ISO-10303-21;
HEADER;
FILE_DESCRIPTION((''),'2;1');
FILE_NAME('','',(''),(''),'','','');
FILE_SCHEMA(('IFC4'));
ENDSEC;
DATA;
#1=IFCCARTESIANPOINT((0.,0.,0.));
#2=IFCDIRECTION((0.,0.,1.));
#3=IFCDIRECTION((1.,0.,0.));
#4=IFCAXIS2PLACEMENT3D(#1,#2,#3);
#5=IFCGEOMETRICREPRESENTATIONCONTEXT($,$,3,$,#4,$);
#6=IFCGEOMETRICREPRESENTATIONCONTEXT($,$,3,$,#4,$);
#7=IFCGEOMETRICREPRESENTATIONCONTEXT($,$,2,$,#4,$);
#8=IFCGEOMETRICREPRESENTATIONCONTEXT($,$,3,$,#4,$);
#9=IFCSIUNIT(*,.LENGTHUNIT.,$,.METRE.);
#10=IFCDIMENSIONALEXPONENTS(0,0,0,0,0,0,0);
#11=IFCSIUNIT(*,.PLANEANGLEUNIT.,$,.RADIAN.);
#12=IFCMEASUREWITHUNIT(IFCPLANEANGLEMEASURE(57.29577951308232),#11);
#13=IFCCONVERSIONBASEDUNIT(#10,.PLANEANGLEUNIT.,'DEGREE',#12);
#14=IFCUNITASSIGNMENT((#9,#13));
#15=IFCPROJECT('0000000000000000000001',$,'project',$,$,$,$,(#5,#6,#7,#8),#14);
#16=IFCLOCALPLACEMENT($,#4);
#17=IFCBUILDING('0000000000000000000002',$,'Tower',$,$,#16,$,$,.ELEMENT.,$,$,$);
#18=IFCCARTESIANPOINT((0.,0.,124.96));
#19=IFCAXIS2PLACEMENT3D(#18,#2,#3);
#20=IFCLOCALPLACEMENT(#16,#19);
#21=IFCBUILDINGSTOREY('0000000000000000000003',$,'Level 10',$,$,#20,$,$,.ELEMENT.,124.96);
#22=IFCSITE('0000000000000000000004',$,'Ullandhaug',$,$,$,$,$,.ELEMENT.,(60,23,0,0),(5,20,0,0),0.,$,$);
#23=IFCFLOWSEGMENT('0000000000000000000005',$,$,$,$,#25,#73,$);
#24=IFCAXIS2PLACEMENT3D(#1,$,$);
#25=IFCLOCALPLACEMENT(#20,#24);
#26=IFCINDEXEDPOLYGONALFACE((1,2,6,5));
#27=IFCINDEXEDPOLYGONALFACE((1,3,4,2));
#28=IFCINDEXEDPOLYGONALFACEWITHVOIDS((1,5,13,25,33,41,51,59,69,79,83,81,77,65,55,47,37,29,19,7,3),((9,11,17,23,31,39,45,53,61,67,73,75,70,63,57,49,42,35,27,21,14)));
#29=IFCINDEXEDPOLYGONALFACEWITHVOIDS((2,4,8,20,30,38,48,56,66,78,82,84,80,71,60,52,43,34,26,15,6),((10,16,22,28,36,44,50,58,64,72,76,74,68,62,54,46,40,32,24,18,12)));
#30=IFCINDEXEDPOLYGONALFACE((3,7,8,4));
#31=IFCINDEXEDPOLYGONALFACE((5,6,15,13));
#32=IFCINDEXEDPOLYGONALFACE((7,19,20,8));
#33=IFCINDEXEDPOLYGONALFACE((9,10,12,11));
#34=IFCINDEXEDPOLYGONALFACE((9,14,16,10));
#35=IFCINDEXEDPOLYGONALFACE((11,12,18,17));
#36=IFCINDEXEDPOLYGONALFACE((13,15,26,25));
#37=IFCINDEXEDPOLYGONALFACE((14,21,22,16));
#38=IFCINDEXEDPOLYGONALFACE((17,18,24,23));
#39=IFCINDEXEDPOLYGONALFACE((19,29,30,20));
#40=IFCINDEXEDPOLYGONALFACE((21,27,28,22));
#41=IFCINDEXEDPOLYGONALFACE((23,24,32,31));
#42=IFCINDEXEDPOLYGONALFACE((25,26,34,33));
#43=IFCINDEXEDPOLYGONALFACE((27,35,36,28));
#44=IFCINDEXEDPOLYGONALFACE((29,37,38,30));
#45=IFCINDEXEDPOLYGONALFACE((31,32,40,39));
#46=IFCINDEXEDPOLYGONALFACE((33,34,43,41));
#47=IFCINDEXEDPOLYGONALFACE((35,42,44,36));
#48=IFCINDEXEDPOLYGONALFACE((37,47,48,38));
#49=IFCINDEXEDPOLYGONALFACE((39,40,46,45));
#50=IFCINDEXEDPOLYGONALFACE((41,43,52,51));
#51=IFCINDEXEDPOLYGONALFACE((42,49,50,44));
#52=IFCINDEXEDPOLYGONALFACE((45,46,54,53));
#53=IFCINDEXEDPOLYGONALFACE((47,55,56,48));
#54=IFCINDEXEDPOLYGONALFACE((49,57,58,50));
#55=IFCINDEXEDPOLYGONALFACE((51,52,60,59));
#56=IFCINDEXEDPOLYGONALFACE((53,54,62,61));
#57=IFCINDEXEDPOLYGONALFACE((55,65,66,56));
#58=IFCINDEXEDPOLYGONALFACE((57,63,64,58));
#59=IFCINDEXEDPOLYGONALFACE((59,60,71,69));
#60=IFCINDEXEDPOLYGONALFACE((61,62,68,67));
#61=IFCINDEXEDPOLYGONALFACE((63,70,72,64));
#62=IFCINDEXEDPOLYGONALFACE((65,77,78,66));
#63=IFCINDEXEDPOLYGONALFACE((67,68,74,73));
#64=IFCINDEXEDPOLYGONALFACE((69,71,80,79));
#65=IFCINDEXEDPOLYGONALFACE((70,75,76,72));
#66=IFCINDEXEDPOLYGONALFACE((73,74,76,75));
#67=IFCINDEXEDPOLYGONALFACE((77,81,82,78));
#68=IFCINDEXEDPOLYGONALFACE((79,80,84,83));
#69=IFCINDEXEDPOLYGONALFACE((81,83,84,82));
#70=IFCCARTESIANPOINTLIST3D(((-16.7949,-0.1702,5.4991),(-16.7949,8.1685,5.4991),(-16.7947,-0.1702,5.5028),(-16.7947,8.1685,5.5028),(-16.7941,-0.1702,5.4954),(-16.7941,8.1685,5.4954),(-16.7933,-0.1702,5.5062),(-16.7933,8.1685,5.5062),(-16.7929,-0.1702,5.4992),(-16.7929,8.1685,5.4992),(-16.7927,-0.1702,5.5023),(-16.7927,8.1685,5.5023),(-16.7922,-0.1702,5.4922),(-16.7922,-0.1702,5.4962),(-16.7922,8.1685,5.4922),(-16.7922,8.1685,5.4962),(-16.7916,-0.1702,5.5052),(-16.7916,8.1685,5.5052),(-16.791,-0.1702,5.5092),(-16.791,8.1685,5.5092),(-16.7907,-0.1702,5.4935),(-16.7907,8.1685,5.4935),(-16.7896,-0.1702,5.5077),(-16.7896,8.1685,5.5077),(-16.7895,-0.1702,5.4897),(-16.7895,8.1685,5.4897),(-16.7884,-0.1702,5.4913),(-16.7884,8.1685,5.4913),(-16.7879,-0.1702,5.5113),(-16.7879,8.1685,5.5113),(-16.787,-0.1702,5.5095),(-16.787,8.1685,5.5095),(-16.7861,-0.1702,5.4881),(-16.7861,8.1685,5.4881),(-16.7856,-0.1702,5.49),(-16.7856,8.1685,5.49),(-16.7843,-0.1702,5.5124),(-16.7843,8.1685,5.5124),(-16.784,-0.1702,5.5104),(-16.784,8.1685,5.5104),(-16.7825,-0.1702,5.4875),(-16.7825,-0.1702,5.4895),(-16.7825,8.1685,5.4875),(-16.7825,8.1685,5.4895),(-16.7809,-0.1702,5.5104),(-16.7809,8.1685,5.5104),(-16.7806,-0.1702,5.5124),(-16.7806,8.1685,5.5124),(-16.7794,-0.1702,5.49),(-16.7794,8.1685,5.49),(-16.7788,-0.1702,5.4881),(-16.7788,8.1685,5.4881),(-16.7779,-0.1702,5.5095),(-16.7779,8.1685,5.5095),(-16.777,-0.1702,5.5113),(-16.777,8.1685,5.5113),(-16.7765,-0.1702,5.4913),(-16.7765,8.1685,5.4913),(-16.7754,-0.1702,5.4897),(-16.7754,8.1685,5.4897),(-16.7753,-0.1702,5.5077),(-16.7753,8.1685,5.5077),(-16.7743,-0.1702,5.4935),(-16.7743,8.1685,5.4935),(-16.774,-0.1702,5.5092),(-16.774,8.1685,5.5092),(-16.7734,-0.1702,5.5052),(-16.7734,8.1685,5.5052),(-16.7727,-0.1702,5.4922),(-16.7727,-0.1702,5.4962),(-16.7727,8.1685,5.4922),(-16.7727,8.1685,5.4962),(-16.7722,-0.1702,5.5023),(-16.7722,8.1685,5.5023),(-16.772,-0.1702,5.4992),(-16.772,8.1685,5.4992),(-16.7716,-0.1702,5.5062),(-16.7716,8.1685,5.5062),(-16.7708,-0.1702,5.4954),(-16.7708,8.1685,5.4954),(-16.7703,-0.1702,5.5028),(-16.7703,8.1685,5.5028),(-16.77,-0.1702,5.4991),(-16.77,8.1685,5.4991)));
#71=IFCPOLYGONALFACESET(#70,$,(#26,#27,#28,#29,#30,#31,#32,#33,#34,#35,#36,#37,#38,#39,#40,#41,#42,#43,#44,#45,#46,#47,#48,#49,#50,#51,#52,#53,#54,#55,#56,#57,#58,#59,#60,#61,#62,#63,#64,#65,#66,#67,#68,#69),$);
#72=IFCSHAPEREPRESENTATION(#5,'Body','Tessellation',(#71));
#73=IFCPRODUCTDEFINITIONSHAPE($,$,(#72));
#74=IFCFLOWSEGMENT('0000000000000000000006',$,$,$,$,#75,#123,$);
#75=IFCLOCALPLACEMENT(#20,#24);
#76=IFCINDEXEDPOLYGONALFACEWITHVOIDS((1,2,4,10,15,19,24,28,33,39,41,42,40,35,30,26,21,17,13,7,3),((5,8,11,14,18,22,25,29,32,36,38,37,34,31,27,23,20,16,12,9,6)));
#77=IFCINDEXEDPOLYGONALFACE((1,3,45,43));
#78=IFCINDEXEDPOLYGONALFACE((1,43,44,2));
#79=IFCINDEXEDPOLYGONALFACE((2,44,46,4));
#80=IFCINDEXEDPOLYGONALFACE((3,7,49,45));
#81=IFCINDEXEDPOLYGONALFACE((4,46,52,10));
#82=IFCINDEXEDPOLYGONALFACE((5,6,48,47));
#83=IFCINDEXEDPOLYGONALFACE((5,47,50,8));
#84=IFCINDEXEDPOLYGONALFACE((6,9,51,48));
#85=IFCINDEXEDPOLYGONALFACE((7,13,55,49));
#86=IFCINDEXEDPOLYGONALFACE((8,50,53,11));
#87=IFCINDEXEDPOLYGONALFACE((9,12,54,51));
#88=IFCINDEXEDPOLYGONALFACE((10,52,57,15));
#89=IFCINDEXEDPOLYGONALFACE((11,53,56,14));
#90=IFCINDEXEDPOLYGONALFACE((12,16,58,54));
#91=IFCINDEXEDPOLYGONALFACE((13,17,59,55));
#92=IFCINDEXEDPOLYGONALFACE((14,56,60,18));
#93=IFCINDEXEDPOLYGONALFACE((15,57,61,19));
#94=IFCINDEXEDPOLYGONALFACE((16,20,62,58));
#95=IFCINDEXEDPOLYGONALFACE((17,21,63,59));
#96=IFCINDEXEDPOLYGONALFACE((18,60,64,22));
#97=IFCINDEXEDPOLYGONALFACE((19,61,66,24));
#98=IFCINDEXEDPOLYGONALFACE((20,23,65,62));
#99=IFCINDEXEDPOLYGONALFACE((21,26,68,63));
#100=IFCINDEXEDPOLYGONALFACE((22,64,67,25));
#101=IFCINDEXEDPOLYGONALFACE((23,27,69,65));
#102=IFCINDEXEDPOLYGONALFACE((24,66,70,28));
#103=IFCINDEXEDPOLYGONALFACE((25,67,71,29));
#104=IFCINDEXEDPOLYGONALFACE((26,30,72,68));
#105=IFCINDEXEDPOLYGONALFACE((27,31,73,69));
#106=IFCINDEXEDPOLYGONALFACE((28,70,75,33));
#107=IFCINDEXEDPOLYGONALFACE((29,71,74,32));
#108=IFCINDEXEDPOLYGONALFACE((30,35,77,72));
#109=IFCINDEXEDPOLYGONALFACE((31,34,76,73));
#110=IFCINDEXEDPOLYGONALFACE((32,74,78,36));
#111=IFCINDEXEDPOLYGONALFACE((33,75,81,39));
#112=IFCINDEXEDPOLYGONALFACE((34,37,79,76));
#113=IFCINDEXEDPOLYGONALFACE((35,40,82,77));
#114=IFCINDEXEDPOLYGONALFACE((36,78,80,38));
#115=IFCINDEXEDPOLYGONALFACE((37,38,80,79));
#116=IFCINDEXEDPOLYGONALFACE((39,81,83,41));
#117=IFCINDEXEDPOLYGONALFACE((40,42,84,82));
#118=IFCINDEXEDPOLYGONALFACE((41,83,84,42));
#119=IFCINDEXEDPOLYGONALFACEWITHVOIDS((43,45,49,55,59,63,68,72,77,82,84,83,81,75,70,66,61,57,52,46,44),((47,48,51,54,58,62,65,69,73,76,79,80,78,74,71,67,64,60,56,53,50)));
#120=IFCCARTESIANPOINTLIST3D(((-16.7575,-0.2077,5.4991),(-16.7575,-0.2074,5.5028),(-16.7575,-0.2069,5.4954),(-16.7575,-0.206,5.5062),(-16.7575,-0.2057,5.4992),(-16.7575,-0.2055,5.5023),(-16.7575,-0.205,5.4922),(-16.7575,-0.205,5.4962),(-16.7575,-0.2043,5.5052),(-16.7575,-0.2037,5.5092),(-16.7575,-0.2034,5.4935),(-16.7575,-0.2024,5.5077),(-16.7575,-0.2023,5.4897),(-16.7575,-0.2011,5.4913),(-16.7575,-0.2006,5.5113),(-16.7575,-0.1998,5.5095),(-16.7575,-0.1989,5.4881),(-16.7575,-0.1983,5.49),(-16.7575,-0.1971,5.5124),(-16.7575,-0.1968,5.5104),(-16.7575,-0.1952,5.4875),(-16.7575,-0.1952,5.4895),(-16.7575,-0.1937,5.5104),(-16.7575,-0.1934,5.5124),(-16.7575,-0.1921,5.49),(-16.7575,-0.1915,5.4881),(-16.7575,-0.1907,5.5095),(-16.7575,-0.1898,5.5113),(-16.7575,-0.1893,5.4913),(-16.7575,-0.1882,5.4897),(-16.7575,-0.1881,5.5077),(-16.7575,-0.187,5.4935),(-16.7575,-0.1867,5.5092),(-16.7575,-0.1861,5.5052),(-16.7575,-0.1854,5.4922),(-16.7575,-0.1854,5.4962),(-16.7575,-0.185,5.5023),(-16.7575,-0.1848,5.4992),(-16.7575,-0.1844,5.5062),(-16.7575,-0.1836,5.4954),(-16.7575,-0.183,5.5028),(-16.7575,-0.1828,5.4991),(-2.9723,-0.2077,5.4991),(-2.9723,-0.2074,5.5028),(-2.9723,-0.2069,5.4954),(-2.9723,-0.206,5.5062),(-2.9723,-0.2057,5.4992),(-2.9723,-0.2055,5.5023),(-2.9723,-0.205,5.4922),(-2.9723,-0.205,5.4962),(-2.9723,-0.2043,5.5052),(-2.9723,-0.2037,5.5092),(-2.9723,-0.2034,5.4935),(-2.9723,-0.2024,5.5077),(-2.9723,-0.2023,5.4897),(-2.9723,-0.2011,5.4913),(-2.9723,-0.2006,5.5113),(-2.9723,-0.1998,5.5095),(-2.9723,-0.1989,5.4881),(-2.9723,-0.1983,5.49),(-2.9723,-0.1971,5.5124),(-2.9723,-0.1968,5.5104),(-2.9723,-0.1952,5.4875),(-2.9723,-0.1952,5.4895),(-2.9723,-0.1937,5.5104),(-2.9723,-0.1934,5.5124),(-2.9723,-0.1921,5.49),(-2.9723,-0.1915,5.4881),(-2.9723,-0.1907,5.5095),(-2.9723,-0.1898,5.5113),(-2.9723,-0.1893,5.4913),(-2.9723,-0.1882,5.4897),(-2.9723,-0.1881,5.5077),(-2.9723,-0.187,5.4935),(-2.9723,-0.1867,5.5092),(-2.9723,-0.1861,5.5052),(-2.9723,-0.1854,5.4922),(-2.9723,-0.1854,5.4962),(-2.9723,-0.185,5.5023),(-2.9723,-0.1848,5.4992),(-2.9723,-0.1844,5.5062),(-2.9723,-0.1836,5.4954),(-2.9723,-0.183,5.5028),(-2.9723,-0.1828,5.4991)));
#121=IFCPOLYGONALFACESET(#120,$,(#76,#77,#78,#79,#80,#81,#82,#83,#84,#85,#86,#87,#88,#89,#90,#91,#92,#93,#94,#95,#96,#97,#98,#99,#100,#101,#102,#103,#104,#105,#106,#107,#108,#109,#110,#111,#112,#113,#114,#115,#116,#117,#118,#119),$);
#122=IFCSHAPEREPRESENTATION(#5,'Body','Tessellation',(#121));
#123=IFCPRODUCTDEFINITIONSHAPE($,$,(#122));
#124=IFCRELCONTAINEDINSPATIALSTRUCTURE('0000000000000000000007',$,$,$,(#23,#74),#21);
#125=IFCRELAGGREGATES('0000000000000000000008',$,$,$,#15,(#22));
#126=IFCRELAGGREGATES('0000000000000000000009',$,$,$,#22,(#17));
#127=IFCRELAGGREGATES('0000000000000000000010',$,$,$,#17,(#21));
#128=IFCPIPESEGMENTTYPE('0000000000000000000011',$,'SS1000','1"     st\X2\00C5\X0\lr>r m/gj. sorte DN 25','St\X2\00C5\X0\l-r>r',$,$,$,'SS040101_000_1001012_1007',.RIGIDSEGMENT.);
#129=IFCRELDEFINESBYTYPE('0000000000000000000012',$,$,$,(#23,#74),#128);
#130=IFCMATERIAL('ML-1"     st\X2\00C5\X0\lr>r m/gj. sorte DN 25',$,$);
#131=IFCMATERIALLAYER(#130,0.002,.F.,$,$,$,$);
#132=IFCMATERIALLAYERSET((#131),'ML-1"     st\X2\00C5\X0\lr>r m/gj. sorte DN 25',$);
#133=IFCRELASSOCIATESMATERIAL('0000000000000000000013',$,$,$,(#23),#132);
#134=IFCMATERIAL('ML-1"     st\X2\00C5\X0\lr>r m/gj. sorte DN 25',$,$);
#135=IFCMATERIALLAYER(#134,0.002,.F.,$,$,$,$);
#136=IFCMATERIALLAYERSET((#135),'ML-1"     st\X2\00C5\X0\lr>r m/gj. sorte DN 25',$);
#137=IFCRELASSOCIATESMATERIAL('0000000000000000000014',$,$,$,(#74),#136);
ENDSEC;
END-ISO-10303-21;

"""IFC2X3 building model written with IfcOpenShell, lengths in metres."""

from ifc_helpers import new_model, entity, si_unit, converted_unit, frame, origin_with_axes, origin_2d_with_axis, place, context, project, spatial, hollow_circle, extrude, material, layer, layer_set, layer_usage, type_object, element, save


model = new_model("IFC2X3")

# Units and contexts
context_of_model_1 = context(None, 3, world=origin_with_axes())
context_of_model_2 = context(None, 3, world=origin_with_axes())
context_of_model_3 = context(None, 2, world=origin_with_axes())
context_of_model_4 = context(None, 3, world=origin_with_axes())
ifc_project = project(units=[si_unit("LENGTHUNIT", "METRE"), converted_unit("PLANEANGLEUNIT", "DEGREE", entity("IfcPlaneAngleMeasure", 57.29577951308232), si_unit("PLANEANGLEUNIT", "RADIAN"), dimensions=[0, 0, 0, 0, 0, 0, 0])], contexts=[context_of_model_1, context_of_model_2, context_of_model_3, context_of_model_4])

# Site, building, storey
site = spatial("IfcSite", under=ifc_project, Name="Ullandhaug", CompositionType="ELEMENT", RefLatitude=(60, 23, 0, 0), RefLongitude=(5, 20, 0, 0), RefElevation=0.0)
building_placement = place(None, origin_with_axes())
building = spatial("IfcBuilding", under=site, at=building_placement, Name="Tower", CompositionType="ELEMENT")
storey_placement = place(building_placement, frame((0.0, 0.0, 124.96), z_axis=(0.0, 0.0, 1.0), x_axis=(1.0, 0.0, 0.0)))
storey = spatial("IfcBuildingStorey", under=building, at=storey_placement, Name="Level 10", CompositionType="ELEMENT", Elevation=124.96)

# Flow segments
ifc_material_1 = material(Name="ML-1\"     stÅlr>r m/gj. sorte DN 25")
ifc_layer_1 = layer(ifc_material_1, 0.002, ventilated=False)
ifc_layer_set_1 = layer_set([ifc_layer_1], Name="ML-1\"     stÅlr>r m/gj. sorte DN 25")
ifc_layer_usage_1 = layer_usage(ifc_layer_set_1, "AXIS2", "POSITIVE", 0.0)
pipe_segment_type_1 = type_object("IfcPipeSegmentType", Name="SS1000", Description="1\"     stÅlr>r m/gj. sorte DN 25", ApplicableOccurrence="StÅl-r>r", ElementType="SS040101_000_1001012_1007", PredefinedType="RIGIDSEGMENT")
flow_segment_1_placement = place(storey_placement, frame((-16.7825, 8.1685, 5.5), z_axis=(0.0, -1.0, 0.0), x_axis=(0.0, 0.0, -1.0)))
element("IfcFlowSegment", 1, at=flow_segment_1_placement, inside=storey, type_object=pipe_segment_type_1, material=ifc_layer_usage_1, context=context_of_model_1, shape_type="SweptSolid", body=[
    extrude(hollow_circle(Radius=0.0125, WallThickness=0.002, at=origin_2d_with_axis()), origin_with_axes(), (0.0, 0.0, 1.0), 8.3387),
])
ifc_material_2 = material(Name="ML-1\"     stÅlr>r m/gj. sorte DN 25")
ifc_layer_2 = layer(ifc_material_2, 0.002, ventilated=False)
ifc_layer_set_2 = layer_set([ifc_layer_2], Name="ML-1\"     stÅlr>r m/gj. sorte DN 25")
ifc_layer_usage_2 = layer_usage(ifc_layer_set_2, "AXIS2", "POSITIVE", 0.0)
flow_segment_2_placement = place(storey_placement, frame((-16.7575, -0.1952, 5.5), z_axis=(1.0, 0.0, 0.0), x_axis=(0.0, 0.0, -1.0)))
element("IfcFlowSegment", 2, at=flow_segment_2_placement, inside=storey, type_object=pipe_segment_type_1, material=ifc_layer_usage_2, context=context_of_model_1, shape_type="SweptSolid", body=[
    extrude(hollow_circle(Radius=0.0125, WallThickness=0.002, at=origin_2d_with_axis()), origin_with_axes(), (0.0, 0.0, 1.0), 13.7851),
])

save(model, "model.ifc")
